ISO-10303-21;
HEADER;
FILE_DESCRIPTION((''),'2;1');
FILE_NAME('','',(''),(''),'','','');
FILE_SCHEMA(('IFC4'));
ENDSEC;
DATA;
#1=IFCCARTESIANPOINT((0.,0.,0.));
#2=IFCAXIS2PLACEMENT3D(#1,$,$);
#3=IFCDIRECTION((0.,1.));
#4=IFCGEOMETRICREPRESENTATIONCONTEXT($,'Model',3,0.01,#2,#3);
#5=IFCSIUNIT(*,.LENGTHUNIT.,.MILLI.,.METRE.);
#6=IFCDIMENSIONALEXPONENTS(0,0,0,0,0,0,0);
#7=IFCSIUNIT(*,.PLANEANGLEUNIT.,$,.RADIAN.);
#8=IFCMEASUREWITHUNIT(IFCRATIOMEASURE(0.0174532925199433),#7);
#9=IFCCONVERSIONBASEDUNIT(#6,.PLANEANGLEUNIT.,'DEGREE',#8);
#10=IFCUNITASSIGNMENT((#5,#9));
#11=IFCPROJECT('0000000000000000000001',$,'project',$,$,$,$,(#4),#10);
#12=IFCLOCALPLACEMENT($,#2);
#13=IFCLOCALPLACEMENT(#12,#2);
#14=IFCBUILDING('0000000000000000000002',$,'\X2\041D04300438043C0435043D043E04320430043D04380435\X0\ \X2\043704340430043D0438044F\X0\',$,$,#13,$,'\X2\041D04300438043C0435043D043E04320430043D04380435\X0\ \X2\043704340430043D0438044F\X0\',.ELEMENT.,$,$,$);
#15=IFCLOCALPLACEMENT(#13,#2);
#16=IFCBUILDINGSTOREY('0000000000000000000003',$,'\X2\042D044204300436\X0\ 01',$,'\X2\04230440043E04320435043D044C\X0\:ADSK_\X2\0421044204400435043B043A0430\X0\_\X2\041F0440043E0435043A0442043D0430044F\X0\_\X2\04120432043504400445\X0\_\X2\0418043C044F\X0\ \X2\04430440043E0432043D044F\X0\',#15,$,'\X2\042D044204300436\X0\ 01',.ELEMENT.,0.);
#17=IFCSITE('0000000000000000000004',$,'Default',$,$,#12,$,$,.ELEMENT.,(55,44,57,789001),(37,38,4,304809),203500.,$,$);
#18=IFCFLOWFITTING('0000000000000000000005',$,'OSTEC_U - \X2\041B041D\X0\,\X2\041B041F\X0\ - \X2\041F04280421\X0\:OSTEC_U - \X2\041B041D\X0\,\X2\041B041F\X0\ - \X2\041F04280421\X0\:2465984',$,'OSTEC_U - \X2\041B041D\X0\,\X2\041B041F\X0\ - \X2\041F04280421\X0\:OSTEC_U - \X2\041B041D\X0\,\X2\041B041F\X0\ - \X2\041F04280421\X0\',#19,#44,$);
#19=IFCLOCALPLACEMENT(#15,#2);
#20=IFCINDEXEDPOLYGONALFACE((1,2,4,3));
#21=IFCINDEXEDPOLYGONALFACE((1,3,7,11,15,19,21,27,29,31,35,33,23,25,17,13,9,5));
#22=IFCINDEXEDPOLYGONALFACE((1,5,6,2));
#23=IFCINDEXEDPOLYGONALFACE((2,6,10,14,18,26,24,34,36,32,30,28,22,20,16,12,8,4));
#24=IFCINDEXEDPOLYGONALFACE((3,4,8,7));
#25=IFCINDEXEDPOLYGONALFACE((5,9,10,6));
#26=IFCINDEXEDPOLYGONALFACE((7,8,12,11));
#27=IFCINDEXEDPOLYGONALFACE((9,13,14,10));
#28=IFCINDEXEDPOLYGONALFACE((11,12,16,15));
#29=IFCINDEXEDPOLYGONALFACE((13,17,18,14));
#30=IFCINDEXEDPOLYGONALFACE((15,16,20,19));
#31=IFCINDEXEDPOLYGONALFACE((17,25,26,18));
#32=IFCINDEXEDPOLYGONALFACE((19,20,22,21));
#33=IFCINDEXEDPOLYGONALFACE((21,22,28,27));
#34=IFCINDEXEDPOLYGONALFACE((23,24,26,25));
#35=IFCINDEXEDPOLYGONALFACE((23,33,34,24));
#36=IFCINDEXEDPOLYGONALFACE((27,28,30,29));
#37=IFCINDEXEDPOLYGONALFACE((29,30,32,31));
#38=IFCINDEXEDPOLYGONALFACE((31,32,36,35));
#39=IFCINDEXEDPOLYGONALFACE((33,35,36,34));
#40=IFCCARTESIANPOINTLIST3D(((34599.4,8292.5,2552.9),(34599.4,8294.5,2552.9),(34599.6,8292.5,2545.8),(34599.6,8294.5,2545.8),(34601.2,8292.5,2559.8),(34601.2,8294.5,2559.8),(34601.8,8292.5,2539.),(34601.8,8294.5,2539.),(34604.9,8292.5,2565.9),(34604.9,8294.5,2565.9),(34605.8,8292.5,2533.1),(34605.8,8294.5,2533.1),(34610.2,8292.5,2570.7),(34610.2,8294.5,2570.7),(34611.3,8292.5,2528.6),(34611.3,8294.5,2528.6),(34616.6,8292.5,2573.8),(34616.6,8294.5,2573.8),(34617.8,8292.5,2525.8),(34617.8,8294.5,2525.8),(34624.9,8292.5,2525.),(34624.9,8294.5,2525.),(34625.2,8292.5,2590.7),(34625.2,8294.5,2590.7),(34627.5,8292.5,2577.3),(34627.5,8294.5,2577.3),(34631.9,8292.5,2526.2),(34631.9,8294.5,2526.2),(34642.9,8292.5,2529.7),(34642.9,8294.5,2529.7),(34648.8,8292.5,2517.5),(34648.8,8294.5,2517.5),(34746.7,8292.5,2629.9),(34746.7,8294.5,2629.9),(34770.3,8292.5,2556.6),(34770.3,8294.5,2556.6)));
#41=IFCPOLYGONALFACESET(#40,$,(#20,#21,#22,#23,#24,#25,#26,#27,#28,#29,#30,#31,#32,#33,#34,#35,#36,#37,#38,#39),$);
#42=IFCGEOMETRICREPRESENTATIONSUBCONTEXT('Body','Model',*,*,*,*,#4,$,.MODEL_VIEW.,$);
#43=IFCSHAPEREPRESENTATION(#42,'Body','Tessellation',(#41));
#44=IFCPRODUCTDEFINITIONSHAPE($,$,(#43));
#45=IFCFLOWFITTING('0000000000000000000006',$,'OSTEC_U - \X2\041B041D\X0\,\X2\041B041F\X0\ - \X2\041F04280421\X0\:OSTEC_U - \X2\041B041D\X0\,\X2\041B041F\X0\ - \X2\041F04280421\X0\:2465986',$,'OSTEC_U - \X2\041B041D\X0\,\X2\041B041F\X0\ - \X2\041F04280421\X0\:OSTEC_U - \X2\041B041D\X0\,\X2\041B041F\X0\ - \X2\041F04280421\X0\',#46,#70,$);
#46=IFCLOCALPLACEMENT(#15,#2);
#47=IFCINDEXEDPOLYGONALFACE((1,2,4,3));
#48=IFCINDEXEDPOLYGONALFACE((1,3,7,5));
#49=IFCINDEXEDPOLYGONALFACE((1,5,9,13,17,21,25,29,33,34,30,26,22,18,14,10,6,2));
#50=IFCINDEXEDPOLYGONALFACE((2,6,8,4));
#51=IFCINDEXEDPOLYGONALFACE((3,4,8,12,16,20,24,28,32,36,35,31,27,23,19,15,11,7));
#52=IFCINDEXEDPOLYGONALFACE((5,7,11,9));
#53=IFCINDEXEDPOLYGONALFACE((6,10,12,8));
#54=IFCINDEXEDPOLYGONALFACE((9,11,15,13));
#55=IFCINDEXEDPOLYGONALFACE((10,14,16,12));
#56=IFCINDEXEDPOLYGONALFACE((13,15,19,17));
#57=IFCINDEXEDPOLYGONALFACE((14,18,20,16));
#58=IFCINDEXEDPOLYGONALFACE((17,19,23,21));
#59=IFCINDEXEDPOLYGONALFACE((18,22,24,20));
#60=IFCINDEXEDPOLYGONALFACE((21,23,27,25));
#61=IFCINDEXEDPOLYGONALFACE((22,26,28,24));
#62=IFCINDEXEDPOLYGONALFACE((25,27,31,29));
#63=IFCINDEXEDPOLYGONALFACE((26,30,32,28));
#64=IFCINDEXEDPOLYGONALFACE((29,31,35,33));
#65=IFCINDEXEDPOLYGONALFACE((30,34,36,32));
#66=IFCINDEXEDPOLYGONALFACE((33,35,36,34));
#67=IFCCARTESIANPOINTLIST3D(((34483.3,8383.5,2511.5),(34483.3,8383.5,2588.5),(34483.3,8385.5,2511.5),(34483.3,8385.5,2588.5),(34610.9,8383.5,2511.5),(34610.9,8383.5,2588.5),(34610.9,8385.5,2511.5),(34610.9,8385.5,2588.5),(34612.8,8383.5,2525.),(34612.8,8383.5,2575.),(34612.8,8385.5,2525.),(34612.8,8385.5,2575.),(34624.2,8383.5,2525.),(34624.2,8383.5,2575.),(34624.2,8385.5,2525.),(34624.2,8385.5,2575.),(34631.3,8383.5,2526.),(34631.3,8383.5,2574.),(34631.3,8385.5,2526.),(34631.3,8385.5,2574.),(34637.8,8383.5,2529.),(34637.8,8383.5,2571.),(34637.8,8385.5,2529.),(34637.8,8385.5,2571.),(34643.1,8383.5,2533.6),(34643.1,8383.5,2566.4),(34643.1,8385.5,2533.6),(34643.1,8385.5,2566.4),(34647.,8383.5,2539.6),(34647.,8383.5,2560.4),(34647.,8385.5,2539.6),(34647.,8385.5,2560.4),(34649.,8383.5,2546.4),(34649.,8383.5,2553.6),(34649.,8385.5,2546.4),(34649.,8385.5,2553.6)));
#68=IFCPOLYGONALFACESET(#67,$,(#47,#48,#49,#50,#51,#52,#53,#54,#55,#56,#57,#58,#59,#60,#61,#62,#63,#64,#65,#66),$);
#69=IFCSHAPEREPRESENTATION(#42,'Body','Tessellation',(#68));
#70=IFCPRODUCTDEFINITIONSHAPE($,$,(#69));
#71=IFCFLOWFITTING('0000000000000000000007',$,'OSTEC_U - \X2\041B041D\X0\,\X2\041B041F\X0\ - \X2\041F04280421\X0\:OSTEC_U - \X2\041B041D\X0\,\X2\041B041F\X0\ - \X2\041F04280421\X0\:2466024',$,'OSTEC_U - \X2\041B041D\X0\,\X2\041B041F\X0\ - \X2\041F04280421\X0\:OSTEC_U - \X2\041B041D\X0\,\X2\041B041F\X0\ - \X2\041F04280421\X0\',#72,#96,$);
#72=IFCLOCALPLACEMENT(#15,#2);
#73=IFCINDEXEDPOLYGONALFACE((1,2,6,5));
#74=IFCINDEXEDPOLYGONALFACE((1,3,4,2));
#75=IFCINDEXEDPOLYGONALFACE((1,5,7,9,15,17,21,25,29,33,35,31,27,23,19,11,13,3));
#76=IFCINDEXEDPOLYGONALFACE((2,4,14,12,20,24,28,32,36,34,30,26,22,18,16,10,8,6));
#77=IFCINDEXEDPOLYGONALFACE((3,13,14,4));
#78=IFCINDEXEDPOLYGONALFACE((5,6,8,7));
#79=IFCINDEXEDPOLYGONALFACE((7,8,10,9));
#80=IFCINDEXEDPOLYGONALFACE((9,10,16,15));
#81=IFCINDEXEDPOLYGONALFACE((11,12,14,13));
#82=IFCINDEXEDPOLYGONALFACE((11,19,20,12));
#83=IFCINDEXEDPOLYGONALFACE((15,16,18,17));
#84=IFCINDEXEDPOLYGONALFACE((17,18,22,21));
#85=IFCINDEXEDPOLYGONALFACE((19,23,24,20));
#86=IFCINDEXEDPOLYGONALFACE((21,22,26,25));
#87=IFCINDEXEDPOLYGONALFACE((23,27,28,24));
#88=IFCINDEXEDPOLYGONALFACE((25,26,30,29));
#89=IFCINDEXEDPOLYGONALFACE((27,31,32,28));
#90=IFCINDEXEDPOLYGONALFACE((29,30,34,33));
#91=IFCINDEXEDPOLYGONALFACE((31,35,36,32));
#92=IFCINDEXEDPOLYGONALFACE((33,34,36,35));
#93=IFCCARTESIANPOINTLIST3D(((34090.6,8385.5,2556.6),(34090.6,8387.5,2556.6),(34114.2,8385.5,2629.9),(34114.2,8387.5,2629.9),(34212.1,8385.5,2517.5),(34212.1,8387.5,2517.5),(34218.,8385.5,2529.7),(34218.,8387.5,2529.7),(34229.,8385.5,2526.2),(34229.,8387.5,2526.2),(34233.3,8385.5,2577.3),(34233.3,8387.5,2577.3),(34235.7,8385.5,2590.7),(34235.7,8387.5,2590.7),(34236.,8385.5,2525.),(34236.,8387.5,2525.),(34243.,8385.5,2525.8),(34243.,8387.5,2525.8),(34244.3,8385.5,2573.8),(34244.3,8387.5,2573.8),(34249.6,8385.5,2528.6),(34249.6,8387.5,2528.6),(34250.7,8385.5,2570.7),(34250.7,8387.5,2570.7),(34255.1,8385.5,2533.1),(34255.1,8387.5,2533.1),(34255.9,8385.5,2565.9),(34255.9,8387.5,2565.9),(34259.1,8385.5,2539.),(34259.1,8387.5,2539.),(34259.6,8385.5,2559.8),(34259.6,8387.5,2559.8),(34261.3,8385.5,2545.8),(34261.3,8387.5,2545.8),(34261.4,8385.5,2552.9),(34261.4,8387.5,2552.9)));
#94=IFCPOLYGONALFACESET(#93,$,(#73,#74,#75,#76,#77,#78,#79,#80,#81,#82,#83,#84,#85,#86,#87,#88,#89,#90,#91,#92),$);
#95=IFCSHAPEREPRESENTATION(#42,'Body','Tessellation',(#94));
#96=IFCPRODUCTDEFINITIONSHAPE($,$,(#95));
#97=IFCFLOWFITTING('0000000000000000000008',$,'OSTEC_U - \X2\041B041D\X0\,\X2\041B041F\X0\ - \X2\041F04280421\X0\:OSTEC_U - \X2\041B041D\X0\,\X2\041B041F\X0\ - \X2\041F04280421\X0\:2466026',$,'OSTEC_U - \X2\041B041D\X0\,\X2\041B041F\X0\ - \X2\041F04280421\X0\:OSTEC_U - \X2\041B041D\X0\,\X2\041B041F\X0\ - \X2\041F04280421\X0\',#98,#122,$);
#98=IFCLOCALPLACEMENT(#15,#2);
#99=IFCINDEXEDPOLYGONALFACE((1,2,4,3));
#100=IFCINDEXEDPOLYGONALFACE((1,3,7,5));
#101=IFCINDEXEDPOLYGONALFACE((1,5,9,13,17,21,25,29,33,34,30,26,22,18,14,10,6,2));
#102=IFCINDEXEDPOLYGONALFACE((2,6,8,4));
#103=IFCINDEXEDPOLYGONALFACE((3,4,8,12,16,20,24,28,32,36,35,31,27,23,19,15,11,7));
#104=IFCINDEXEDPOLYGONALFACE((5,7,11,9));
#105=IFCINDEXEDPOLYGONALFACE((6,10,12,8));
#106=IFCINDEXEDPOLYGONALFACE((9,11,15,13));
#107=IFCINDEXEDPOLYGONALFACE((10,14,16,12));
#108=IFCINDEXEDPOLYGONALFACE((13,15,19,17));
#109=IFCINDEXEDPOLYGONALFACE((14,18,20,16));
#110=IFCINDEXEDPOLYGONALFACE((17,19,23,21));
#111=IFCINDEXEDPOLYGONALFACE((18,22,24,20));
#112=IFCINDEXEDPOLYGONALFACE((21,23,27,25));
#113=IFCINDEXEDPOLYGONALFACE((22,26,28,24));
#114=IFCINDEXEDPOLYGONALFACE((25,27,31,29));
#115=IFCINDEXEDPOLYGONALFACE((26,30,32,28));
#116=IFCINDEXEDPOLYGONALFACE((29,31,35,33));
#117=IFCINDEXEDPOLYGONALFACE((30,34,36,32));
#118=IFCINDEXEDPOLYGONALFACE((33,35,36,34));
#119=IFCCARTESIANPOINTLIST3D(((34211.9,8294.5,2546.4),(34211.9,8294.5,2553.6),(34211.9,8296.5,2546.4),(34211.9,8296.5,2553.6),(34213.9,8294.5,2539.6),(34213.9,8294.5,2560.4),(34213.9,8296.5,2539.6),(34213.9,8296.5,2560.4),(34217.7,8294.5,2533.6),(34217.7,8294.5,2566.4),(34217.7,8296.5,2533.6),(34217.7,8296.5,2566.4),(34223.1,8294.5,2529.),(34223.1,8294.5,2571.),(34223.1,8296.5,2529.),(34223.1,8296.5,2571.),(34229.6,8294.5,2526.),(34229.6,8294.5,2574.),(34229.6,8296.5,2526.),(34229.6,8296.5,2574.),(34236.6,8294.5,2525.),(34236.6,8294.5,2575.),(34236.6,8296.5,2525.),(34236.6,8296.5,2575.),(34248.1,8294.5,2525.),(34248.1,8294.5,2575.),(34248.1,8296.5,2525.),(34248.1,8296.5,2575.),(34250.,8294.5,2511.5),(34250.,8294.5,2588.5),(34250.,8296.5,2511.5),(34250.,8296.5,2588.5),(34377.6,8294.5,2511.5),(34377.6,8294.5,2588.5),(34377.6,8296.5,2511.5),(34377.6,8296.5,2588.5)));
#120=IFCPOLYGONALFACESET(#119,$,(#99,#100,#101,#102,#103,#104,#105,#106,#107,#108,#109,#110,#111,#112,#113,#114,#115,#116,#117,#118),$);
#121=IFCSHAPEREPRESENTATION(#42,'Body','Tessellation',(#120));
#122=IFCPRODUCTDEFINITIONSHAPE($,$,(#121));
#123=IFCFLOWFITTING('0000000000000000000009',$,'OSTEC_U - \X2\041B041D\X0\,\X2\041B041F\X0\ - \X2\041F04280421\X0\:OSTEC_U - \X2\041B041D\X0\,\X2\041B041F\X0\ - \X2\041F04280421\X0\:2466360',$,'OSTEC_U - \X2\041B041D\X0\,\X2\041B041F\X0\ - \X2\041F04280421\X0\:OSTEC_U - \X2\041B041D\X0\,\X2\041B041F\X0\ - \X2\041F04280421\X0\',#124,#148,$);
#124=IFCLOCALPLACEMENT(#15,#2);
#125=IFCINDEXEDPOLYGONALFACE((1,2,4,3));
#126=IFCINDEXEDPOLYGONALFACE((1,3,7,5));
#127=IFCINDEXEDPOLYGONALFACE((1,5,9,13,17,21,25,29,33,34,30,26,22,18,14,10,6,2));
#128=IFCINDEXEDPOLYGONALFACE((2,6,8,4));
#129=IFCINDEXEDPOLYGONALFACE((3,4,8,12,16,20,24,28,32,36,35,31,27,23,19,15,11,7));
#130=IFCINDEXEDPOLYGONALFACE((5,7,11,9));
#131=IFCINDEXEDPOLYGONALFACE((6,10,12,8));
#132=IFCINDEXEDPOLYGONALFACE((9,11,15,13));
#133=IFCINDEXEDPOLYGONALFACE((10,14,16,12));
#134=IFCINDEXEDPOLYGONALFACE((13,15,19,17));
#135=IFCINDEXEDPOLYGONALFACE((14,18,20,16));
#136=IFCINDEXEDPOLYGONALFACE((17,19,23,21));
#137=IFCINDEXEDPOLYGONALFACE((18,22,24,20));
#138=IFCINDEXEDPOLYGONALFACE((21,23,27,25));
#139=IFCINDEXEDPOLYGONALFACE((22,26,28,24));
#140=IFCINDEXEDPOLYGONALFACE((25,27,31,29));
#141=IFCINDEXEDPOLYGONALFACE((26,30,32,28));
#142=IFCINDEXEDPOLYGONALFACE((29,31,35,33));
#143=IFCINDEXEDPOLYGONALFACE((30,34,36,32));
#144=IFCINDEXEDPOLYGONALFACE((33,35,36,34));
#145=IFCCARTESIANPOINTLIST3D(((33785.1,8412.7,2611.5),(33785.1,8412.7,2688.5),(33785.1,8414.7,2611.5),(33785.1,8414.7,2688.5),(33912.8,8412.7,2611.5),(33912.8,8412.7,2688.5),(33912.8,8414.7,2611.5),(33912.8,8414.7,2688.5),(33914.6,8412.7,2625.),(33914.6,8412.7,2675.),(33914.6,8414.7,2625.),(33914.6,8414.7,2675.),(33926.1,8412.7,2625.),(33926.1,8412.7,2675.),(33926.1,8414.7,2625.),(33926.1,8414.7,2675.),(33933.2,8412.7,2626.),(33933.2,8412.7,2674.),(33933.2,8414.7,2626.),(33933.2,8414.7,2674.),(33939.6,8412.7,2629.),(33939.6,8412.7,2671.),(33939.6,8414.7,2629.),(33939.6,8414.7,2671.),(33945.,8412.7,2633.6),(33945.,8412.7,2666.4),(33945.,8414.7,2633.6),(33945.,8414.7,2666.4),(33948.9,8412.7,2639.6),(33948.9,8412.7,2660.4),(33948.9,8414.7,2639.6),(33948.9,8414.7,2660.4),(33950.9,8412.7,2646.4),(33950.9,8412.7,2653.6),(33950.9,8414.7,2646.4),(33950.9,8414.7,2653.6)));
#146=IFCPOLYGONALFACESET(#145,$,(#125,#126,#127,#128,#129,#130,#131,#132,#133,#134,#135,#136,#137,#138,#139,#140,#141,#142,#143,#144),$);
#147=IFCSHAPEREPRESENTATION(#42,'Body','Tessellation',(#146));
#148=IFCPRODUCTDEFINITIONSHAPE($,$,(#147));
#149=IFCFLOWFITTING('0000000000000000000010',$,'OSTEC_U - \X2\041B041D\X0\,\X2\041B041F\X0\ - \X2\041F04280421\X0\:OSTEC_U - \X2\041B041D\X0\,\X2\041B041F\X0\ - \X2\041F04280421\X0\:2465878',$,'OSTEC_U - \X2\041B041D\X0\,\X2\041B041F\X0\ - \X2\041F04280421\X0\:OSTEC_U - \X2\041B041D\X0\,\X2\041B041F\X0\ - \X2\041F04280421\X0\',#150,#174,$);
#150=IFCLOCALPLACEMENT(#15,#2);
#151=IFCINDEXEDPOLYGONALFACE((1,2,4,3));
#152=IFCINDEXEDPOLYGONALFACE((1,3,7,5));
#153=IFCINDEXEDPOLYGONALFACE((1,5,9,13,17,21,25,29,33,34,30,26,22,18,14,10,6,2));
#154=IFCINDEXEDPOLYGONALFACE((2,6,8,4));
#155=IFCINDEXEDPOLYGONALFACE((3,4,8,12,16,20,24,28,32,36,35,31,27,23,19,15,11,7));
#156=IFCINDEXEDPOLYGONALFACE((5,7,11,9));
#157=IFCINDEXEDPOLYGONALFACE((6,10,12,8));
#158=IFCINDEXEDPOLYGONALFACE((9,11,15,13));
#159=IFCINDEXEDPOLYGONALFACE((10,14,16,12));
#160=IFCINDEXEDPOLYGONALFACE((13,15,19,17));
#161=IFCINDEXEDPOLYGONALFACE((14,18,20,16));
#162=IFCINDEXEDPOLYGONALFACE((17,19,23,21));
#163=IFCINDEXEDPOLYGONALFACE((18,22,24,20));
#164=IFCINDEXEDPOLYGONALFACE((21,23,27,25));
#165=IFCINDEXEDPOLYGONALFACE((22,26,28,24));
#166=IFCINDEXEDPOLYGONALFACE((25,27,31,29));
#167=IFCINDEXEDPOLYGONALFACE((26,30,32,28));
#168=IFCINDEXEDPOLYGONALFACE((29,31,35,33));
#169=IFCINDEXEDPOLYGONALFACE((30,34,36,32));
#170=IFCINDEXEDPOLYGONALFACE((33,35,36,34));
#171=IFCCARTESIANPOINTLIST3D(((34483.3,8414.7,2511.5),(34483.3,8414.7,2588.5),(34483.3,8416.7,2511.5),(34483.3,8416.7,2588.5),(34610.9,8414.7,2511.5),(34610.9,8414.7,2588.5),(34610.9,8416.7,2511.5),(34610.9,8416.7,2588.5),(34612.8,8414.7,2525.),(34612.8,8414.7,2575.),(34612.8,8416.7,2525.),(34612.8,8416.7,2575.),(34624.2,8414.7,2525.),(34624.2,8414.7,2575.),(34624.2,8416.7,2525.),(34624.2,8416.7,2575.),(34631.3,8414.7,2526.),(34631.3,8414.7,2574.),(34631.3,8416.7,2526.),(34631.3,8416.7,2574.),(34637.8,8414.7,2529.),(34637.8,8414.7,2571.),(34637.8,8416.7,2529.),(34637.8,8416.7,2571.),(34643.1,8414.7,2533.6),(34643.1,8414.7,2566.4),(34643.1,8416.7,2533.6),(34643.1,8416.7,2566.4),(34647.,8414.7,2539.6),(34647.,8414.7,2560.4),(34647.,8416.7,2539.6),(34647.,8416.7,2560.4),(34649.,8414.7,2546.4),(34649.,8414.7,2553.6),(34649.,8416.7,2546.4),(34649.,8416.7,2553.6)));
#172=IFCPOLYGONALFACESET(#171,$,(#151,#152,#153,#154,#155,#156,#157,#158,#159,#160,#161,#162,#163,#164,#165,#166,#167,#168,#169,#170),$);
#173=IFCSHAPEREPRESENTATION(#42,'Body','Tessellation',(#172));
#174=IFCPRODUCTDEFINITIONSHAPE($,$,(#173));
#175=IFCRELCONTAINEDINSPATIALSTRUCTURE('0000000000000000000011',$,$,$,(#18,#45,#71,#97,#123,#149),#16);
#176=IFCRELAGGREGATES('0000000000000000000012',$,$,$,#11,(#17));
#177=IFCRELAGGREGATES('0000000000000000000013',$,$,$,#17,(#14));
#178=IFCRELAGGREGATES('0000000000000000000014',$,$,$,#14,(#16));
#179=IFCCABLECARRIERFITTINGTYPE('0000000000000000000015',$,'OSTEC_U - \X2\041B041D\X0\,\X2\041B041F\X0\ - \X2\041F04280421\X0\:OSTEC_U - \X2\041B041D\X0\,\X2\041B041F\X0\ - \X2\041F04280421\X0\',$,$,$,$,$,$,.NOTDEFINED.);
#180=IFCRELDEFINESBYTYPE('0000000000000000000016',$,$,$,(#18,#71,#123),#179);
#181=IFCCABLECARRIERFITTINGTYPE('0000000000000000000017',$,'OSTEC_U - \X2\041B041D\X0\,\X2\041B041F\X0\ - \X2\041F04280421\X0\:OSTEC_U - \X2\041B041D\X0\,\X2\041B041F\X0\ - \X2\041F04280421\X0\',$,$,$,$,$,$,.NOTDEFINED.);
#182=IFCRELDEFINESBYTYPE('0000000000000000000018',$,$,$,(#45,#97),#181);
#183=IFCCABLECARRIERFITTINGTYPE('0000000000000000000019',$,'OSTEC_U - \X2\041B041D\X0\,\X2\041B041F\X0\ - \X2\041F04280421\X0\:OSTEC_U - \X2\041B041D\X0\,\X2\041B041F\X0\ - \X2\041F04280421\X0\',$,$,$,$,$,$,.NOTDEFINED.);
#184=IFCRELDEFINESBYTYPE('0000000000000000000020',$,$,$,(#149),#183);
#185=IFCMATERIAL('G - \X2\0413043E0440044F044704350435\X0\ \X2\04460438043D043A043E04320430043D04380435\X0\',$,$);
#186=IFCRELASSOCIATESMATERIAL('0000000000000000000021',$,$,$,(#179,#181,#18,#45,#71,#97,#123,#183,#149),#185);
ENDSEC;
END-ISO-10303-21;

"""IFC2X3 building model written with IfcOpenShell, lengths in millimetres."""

from ifc_helpers import new_model, entity, si_unit, converted_unit, direction, frame, frame_2d, origin, place, context, subcontext, project, spatial, polyline, circle_curve, parameter, trimmed, segment, composite_curve, outline, extrude, source, transform, mapped, material, type_object, type_shapes, element, save


model = new_model("IFC2X3")

# Units and contexts
model_context = context("Model", 3, precision=0.01, world=origin(), true_north=direction((0.0, 1.0)))
body_context = subcontext(model_context, "Body", "Model", "MODEL_VIEW")
ifc_project = project(units=[si_unit("LENGTHUNIT", "METRE", prefix="MILLI"), converted_unit("PLANEANGLEUNIT", "DEGREE", entity("IfcRatioMeasure", 0.0174532925199433), si_unit("PLANEANGLEUNIT", "RADIAN"), dimensions=[0, 0, 0, 0, 0, 0, 0])], contexts=[model_context])

# Site, building, storey
site_placement = place(None, origin())
site = spatial("IfcSite", under=ifc_project, at=site_placement, Name="Default", CompositionType="ELEMENT", RefLatitude=(55, 44, 57, 789001), RefLongitude=(37, 38, 4, 304809), RefElevation=203500.0)
building_placement = place(site_placement, origin())
building = spatial("IfcBuilding", under=site, at=building_placement, Name="Наименование здания", LongName="Наименование здания", CompositionType="ELEMENT")
storey_placement = place(building_placement, origin())
storey = spatial("IfcBuildingStorey", under=building, at=storey_placement, Name="Этаж 01", ObjectType="Уровень:ADSK_Стрелка_Проектная_Вверх_Имя уровня", LongName="Этаж 01", CompositionType="ELEMENT", Elevation=0.0)

# Flow fittings
ifc_material = material(Name="G - Горячее цинкование")
cable_carrier_fitting_type_1 = type_object("IfcCableCarrierFittingType", Name="OSTEC_U - ЛН,ЛП - ПШС:OSTEC_U - ЛН,ЛП - ПШС", PredefinedType="NOTDEFINED", material=ifc_material)
shared_shape_1 = source(origin(), body_context, "Body", "SweptSolid", [
    extrude(outline(composite_curve([segment(trimmed(circle_curve(frame_2d((-41.5, 0.0), x_axis=(1.0, 0.0)), 25.0), [parameter(90.0)], [parameter(270.0)], True, "PARAMETER"), True, "CONTINUOUS"), segment(polyline([(-41.5, -25.0), (-30.0, -25.0)]), True, "CONTINUOUS"), segment(polyline([(-30.0, -25.0), (-28.1, -38.5)]), True, "CONTINUOUS"), segment(polyline([(-28.1, -38.5), (99.5, -38.5)]), True, "CONTINUOUS"), segment(polyline([(99.5, -38.5), (99.5, 38.5)]), True, "CONTINUOUS"), segment(polyline([(99.5, 38.5), (-28.1, 38.5)]), True, "CONTINUOUS"), segment(polyline([(-28.1, 38.5), (-30.0, 25.0)]), True, "CONTINUOUS"), segment(polyline([(-30.0, 25.0), (-41.5, 25.0)]), True, "CONTINUOUS")], self_intersect=False)), frame((41.5, 0.0, 0.0), z_axis=(0.0, 0.0, -1.0), x_axis=(1.0, 0.0, 0.0)), (0.0, 0.0, -1.0), 2.0),
])
type_shapes(cable_carrier_fitting_type_1, [shared_shape_1])
cable_carrier_fitting_type_2 = type_object("IfcCableCarrierFittingType", Name="OSTEC_U - ЛН,ЛП - ПШС:OSTEC_U - ЛН,ЛП - ПШС", PredefinedType="NOTDEFINED", material=ifc_material)
type_shapes(cable_carrier_fitting_type_2, [shared_shape_1])
flow_fitting_1_placement = place(storey_placement, frame((34624.2, 8294.5, 2550.0), z_axis=(0.0, -1.0, 0.0), x_axis=(0.951851, 0.0, 0.30656)))
element("IfcFlowFitting", 1, at=flow_fitting_1_placement, inside=storey, type_object=cable_carrier_fitting_type_1, material=ifc_material, Name="OSTEC_U - ЛН,ЛП - ПШС:OSTEC_U - ЛН,ЛП - ПШС:2465984", ObjectType="OSTEC_U - ЛН,ЛП - ПШС:OSTEC_U - ЛН,ЛП - ПШС", context=body_context, shape_type="MappedRepresentation", body=[
    mapped(shared_shape_1, transform((0.0, 0.0, 0.0), scale=1.0)),
])
flow_fitting_2_placement = place(storey_placement, frame((34624.2, 8383.5, 2550.0), z_axis=(0.0, 1.0, 0.0), x_axis=(-1.0, 0.0, 0.0)))
element("IfcFlowFitting", 2, at=flow_fitting_2_placement, inside=storey, type_object=cable_carrier_fitting_type_2, material=ifc_material, Name="OSTEC_U - ЛН,ЛП - ПШС:OSTEC_U - ЛН,ЛП - ПШС:2465986", ObjectType="OSTEC_U - ЛН,ЛП - ПШС:OSTEC_U - ЛН,ЛП - ПШС", context=body_context, shape_type="MappedRepresentation", body=[
    mapped(shared_shape_1, transform((0.0, 0.0, 0.0), scale=1.0)),
])
flow_fitting_3_placement = place(storey_placement, frame((34236.6, 8385.5, 2550.0), z_axis=(0.0, 1.0, 0.0), x_axis=(-0.951851, 0.0, 0.30656)))
element("IfcFlowFitting", 3, at=flow_fitting_3_placement, inside=storey, type_object=cable_carrier_fitting_type_1, material=ifc_material, Name="OSTEC_U - ЛН,ЛП - ПШС:OSTEC_U - ЛН,ЛП - ПШС:2466024", ObjectType="OSTEC_U - ЛН,ЛП - ПШС:OSTEC_U - ЛН,ЛП - ПШС", context=body_context, shape_type="MappedRepresentation", body=[
    mapped(shared_shape_1, transform((0.0, 0.0, 0.0), scale=1.0)),
])
flow_fitting_4_placement = place(storey_placement, frame((34236.6, 8296.5, 2550.0), z_axis=(0.0, -1.0, 0.0), x_axis=(1.0, 0.0, 0.0)))
element("IfcFlowFitting", 4, at=flow_fitting_4_placement, inside=storey, type_object=cable_carrier_fitting_type_2, material=ifc_material, Name="OSTEC_U - ЛН,ЛП - ПШС:OSTEC_U - ЛН,ЛП - ПШС:2466026", ObjectType="OSTEC_U - ЛН,ЛП - ПШС:OSTEC_U - ЛН,ЛП - ПШС", context=body_context, shape_type="MappedRepresentation", body=[
    mapped(shared_shape_1, transform((0.0, 0.0, 0.0), scale=1.0)),
])
flow_fitting_5_placement = place(storey_placement, frame((33926.1, 8414.7, 2650.0), z_axis=(0.0, -1.0, 0.0), x_axis=(-1.0, 0.0, 0.0)))
element("IfcFlowFitting", 5, at=flow_fitting_5_placement, inside=storey, type_object=cable_carrier_fitting_type_1, material=ifc_material, Name="OSTEC_U - ЛН,ЛП - ПШС:OSTEC_U - ЛН,ЛП - ПШС:2466360", ObjectType="OSTEC_U - ЛН,ЛП - ПШС:OSTEC_U - ЛН,ЛП - ПШС", context=body_context, shape_type="MappedRepresentation", body=[
    mapped(shared_shape_1, transform((0.0, 0.0, 0.0), scale=1.0)),
])
cable_carrier_fitting_type_3 = type_object("IfcCableCarrierFittingType", Name="OSTEC_U - ЛН,ЛП - ПШС:OSTEC_U - ЛН,ЛП - ПШС", PredefinedType="NOTDEFINED", material=ifc_material)
shared_shape_2 = source(origin(), body_context, "Body", "SweptSolid", [
    extrude(outline(composite_curve([segment(trimmed(circle_curve(frame_2d((-41.5, 0.0), x_axis=(1.0, 0.0)), 25.0), [parameter(90.0)], [parameter(270.0)], True, "PARAMETER"), True, "CONTINUOUS"), segment(polyline([(-41.5, -25.0), (-30.0, -25.0)]), True, "CONTINUOUS"), segment(polyline([(-30.0, -25.0), (-28.1, -38.5)]), True, "CONTINUOUS"), segment(polyline([(-28.1, -38.5), (99.5, -38.5)]), True, "CONTINUOUS"), segment(polyline([(99.5, -38.5), (99.5, 38.5)]), True, "CONTINUOUS"), segment(polyline([(99.5, 38.5), (-28.1, 38.5)]), True, "CONTINUOUS"), segment(polyline([(-28.1, 38.5), (-30.0, 25.0)]), True, "CONTINUOUS"), segment(polyline([(-30.0, 25.0), (-41.5, 25.0)]), True, "CONTINUOUS")], self_intersect=False)), frame((41.5, 0.0, 0.0)), (0.0, 0.0, 1.0), 2.0),
])
type_shapes(cable_carrier_fitting_type_3, [shared_shape_2])
flow_fitting_6_placement = place(storey_placement, frame((34624.2, 8416.7, 2550.0), z_axis=(0.0, -1.0, 0.0), x_axis=(-1.0, 0.0, 0.0)))
element("IfcFlowFitting", 6, at=flow_fitting_6_placement, inside=storey, type_object=cable_carrier_fitting_type_3, material=ifc_material, Name="OSTEC_U - ЛН,ЛП - ПШС:OSTEC_U - ЛН,ЛП - ПШС:2465878", ObjectType="OSTEC_U - ЛН,ЛП - ПШС:OSTEC_U - ЛН,ЛП - ПШС", context=body_context, shape_type="MappedRepresentation", body=[
    mapped(shared_shape_2, transform((0.0, 0.0, 0.0), scale=1.0)),
])

save(model, "model.ifc")
